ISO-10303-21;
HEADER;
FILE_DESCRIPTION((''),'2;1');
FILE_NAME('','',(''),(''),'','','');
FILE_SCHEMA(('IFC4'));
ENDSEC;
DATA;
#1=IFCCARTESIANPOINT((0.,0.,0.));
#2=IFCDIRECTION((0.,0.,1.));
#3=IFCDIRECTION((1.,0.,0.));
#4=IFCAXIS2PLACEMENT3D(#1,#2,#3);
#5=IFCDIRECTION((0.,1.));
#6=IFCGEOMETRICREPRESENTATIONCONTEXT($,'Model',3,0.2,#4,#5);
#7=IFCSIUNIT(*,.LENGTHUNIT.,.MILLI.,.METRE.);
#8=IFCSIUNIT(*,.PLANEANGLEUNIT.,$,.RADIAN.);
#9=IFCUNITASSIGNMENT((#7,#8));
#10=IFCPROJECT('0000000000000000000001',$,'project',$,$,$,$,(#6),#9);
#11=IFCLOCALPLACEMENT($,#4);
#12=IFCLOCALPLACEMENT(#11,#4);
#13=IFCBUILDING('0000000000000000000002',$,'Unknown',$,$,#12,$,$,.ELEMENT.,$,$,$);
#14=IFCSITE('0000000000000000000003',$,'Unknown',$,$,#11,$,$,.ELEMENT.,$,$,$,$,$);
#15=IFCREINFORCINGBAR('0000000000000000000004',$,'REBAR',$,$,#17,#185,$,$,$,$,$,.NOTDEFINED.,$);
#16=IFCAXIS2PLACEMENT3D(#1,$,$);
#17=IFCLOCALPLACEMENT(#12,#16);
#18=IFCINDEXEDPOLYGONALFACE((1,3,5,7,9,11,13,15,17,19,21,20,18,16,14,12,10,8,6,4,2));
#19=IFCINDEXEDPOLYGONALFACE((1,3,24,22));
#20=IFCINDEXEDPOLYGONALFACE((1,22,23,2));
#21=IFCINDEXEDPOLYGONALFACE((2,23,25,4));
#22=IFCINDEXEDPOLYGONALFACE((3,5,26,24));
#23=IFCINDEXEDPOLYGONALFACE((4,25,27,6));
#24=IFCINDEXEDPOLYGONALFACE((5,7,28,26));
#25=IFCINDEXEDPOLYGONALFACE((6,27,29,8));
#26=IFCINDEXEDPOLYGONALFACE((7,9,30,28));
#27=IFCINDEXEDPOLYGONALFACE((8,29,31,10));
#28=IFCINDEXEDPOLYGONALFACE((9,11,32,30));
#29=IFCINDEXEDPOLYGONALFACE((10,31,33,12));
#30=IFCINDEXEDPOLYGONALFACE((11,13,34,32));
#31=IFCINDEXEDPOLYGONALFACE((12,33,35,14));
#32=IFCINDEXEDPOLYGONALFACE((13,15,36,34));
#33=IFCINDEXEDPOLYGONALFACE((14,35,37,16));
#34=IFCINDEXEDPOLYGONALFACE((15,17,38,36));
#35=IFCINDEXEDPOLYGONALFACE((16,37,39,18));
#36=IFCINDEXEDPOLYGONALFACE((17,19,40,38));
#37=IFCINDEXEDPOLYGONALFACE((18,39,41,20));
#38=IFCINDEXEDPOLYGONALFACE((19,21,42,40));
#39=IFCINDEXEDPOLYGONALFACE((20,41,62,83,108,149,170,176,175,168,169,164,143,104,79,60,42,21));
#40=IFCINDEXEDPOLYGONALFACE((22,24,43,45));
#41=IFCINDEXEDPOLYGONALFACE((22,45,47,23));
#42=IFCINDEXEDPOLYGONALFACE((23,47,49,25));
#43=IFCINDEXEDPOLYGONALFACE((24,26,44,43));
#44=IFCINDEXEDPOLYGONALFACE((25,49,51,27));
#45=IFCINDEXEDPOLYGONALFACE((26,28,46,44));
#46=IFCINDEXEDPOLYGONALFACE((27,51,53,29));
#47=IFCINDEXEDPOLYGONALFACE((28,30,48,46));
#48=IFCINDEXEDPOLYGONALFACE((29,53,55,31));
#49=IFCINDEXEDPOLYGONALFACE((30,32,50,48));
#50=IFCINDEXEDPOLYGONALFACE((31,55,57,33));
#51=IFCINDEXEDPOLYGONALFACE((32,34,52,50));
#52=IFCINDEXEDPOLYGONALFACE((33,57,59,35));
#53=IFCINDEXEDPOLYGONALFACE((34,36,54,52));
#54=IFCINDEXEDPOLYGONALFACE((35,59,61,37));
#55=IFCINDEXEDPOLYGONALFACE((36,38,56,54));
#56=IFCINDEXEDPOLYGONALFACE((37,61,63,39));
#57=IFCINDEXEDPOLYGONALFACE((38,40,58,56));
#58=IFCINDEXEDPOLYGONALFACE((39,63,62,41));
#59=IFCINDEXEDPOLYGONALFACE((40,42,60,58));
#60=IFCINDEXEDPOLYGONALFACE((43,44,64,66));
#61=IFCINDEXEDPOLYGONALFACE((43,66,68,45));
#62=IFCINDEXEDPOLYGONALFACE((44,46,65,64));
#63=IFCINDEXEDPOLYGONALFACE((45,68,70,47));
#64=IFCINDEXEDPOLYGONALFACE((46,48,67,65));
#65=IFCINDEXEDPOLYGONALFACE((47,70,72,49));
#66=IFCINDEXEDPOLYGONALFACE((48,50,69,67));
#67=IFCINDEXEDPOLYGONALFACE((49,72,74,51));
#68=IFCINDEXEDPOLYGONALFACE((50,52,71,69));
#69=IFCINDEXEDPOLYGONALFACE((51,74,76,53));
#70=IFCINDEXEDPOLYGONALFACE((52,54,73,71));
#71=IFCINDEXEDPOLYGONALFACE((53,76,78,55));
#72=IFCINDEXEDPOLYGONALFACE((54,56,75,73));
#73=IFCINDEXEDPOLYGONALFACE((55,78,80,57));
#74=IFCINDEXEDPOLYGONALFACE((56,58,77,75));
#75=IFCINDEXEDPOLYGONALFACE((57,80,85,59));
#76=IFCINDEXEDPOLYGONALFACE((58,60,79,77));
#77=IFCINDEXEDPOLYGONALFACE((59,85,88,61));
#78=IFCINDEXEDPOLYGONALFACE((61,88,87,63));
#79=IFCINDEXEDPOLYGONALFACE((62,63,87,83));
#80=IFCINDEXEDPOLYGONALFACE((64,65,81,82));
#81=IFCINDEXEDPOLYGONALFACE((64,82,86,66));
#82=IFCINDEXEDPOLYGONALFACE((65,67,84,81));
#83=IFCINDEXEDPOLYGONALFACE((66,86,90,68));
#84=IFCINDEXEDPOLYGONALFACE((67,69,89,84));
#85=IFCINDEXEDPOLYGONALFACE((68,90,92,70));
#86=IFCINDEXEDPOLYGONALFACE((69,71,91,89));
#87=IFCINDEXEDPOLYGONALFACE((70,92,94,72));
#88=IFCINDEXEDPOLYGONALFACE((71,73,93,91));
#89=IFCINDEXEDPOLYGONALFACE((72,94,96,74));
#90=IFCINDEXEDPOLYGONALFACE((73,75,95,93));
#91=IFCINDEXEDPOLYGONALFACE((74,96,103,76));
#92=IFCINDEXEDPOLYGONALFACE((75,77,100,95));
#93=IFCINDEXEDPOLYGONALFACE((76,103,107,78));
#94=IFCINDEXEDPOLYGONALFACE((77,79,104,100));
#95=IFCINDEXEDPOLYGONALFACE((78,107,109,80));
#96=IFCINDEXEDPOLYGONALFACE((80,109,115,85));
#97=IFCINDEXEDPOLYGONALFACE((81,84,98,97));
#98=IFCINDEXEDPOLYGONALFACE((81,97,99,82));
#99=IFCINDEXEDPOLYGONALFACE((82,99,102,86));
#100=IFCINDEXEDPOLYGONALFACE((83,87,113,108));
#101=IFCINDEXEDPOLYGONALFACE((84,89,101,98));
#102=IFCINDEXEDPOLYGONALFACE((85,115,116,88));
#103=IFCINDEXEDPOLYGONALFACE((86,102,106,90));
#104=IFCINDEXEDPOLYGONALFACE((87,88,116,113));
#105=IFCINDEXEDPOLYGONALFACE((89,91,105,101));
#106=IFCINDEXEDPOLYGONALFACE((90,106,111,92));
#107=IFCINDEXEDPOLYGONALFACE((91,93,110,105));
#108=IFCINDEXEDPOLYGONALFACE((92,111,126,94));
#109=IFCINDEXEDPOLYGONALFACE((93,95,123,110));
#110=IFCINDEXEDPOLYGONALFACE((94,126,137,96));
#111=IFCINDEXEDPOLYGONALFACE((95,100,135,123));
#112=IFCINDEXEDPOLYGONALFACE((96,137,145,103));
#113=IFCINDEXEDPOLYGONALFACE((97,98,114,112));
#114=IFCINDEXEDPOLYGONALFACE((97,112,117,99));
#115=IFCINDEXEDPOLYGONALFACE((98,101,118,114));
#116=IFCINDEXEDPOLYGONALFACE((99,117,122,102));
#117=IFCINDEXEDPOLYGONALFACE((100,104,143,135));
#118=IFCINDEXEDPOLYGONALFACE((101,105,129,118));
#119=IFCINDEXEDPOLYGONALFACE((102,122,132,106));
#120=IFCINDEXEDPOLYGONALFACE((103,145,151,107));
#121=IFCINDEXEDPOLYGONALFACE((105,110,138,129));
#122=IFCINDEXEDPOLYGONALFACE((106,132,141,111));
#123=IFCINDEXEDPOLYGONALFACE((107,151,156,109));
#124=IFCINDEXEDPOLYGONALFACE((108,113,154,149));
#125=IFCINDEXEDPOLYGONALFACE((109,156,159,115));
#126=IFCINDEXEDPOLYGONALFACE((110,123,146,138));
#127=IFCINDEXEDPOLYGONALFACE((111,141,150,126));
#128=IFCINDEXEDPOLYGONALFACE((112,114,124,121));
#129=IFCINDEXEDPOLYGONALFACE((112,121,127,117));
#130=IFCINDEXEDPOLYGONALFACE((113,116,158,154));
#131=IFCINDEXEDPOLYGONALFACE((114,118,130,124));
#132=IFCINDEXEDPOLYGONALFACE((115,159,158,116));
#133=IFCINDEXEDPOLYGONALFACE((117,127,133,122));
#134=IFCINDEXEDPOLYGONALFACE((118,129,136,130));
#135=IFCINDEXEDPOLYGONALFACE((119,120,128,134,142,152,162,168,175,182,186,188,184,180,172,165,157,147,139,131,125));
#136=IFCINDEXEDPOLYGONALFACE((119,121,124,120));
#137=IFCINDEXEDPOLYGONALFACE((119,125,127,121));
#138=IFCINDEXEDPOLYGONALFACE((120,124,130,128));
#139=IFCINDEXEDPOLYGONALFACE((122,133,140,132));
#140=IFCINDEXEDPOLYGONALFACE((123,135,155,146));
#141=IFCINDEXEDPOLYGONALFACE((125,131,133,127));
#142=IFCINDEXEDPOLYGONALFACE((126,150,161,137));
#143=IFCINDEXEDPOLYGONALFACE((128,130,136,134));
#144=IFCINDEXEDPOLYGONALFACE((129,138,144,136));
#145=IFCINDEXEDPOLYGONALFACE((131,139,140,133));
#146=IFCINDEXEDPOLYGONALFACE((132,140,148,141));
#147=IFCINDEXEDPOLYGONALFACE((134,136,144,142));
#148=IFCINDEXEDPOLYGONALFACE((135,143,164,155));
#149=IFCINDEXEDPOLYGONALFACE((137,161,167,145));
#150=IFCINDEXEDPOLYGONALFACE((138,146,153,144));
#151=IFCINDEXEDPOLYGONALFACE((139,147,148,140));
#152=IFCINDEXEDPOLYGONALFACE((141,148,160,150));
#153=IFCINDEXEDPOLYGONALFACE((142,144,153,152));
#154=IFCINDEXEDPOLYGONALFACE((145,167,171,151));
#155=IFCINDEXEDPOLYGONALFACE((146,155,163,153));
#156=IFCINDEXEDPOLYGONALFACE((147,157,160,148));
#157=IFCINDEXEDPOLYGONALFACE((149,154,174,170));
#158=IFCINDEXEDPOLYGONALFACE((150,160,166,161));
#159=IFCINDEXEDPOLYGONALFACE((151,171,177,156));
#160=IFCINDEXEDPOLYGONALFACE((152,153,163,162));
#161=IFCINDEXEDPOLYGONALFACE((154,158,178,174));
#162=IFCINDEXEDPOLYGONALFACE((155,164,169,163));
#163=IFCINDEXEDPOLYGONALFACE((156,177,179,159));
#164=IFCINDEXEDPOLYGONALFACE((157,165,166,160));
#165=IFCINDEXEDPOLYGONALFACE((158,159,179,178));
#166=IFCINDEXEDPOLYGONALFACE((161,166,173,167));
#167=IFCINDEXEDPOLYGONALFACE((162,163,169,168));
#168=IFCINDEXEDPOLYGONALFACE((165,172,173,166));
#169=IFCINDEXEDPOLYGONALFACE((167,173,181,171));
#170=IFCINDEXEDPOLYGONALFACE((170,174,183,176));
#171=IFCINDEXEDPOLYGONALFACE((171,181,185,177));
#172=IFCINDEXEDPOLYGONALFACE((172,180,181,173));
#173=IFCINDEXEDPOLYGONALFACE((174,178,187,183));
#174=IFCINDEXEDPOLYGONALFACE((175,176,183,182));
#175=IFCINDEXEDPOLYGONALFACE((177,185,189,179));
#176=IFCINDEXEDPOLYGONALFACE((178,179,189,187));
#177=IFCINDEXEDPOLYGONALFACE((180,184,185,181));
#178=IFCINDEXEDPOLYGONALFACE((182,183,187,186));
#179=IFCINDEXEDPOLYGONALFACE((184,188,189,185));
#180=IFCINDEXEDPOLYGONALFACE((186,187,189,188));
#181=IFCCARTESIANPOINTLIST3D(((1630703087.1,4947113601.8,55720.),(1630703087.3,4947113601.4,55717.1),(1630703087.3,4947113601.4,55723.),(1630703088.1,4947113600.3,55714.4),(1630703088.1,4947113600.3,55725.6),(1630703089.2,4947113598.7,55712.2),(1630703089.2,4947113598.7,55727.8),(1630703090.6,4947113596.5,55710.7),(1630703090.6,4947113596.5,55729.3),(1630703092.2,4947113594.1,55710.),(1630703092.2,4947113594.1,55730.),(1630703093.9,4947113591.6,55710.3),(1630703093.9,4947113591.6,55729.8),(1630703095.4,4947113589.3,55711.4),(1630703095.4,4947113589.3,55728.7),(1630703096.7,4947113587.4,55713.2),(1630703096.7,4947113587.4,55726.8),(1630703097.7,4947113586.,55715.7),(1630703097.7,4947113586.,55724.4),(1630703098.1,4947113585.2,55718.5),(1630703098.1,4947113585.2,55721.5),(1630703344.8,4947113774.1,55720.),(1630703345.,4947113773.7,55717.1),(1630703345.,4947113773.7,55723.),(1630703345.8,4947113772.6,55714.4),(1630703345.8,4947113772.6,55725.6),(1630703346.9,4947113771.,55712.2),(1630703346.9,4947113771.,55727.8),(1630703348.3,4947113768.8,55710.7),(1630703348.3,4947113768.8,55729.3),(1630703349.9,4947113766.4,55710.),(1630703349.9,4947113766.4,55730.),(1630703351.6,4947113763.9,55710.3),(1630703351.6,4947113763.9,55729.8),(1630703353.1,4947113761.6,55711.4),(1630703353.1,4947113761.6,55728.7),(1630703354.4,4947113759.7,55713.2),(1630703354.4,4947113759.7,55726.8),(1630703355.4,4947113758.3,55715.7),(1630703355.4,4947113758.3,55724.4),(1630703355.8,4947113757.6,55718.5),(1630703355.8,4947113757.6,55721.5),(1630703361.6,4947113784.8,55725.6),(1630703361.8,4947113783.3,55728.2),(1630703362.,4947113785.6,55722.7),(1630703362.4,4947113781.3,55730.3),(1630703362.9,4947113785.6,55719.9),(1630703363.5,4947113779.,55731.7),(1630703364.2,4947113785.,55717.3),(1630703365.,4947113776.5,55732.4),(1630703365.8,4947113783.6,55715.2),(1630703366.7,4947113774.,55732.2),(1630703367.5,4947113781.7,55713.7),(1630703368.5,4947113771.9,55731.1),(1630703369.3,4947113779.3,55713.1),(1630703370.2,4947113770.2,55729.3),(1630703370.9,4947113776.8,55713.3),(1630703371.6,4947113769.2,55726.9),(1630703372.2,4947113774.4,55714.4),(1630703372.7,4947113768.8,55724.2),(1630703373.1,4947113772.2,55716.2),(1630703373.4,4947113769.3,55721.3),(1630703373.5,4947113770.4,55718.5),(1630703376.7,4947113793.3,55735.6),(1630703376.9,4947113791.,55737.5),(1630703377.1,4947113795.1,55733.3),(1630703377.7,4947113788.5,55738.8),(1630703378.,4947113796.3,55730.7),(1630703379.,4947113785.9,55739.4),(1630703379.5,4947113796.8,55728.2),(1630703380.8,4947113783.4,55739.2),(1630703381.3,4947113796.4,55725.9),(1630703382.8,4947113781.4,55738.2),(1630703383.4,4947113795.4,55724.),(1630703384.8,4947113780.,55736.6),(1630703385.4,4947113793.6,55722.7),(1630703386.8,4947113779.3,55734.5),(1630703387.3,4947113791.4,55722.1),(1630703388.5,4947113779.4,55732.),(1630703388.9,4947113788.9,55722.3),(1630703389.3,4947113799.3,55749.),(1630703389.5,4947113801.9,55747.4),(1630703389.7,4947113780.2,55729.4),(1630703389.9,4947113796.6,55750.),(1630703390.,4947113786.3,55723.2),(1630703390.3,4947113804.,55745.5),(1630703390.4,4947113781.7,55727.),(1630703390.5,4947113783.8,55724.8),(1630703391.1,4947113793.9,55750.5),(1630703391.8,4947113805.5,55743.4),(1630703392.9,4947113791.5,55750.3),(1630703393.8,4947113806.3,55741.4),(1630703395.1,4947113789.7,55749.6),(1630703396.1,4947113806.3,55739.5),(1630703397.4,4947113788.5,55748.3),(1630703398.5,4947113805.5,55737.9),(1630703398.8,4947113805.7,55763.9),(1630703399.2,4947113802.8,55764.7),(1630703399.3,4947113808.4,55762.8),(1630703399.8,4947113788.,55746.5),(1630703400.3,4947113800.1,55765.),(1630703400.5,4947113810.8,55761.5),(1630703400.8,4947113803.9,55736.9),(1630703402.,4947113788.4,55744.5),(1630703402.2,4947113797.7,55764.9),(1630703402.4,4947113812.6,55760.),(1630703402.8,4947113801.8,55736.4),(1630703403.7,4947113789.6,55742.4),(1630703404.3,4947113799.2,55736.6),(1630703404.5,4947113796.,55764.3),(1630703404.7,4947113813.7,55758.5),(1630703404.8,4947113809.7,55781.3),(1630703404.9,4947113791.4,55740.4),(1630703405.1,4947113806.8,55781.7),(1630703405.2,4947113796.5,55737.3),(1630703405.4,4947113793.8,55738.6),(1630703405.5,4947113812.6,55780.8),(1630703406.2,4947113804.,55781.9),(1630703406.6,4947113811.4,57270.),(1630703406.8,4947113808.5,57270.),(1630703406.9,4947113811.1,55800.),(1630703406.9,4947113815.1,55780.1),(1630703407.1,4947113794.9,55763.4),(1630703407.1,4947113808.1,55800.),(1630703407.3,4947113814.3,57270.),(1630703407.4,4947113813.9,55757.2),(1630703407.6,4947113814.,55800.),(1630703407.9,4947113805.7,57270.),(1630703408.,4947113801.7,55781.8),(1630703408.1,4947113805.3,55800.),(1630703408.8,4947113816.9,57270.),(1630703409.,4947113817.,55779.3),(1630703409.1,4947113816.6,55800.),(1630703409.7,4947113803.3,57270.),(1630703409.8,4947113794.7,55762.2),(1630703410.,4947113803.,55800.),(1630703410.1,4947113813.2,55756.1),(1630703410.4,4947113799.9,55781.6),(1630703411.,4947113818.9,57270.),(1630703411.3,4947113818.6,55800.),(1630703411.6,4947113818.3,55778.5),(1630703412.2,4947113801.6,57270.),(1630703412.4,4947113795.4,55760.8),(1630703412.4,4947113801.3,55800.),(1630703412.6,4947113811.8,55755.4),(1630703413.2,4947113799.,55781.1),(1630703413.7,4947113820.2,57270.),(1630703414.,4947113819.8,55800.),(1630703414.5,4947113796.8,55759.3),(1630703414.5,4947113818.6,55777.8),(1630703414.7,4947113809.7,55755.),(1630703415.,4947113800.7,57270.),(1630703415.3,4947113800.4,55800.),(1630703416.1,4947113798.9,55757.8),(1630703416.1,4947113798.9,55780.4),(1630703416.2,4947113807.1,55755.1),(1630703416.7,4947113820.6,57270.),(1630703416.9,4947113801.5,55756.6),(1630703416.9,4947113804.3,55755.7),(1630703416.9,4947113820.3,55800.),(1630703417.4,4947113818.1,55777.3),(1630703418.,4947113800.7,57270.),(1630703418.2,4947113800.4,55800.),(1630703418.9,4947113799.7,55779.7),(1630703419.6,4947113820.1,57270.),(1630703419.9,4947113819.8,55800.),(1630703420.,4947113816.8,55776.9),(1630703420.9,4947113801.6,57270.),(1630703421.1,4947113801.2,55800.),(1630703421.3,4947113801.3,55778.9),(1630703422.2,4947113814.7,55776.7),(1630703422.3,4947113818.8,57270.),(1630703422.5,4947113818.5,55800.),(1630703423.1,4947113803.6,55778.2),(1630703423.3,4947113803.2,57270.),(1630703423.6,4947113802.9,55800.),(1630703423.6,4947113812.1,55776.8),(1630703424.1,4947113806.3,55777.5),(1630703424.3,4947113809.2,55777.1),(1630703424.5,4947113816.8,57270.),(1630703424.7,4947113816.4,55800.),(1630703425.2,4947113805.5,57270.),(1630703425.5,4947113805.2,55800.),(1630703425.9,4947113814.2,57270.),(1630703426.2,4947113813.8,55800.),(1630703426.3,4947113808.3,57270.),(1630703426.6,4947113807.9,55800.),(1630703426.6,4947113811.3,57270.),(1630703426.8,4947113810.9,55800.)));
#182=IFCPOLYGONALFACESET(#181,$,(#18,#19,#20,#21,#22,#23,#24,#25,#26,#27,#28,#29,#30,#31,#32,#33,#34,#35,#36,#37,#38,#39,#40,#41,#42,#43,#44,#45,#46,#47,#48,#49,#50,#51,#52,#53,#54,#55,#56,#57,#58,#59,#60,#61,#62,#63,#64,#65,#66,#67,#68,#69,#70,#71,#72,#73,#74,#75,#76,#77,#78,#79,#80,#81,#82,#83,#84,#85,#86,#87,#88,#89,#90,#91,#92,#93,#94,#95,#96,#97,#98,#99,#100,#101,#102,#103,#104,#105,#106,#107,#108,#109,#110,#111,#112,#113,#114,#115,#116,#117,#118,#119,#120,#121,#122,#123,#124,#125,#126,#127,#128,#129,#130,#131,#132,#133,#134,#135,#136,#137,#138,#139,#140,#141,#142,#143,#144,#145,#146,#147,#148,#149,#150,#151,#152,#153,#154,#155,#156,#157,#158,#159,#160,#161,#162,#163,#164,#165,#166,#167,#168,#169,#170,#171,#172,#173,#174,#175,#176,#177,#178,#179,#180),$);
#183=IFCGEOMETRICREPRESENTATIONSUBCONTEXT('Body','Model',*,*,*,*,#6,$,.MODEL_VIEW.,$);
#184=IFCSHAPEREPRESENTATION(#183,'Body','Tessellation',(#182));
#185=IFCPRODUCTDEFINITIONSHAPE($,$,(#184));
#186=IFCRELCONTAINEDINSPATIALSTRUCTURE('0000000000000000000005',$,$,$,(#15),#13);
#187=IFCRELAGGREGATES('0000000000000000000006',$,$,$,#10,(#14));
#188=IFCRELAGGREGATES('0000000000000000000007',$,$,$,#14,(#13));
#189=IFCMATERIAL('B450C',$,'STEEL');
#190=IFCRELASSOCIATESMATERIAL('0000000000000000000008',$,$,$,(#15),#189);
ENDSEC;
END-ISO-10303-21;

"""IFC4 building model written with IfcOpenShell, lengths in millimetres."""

from ifc_helpers import new_model, entity, si_unit, direction, frame, origin_with_axes, place, context, subcontext, project, spatial, material, element, save


model = new_model("IFC4")

# Units and contexts
model_context = context("Model", 3, precision=0.2, world=origin_with_axes(), true_north=direction((0.0, 1.0)))
body_context = subcontext(model_context, "Body", "Model", "MODEL_VIEW")
ifc_project = project(units=[si_unit("LENGTHUNIT", "METRE", prefix="MILLI"), si_unit("PLANEANGLEUNIT", "RADIAN")], contexts=[model_context])

# Site, building
site_placement = place(None, origin_with_axes())
site = spatial("IfcSite", under=ifc_project, at=site_placement, Name="Unknown", CompositionType="ELEMENT")
building_placement = place(site_placement, origin_with_axes())
building = spatial("IfcBuilding", under=site, at=building_placement, Name="Unknown", CompositionType="ELEMENT")

# Reinforcing bar
ifc_material = material(Name="B450C", Category="STEEL")
reinforcing_bar_1_placement = place(building_placement, frame((1630703430.6, 4947113879.6, 55670.0), z_axis=(0.555817, -0.831305, 0.0), x_axis=(0.0, 0.0, 1.0)))
element("IfcReinforcingBar", 1, at=reinforcing_bar_1_placement, inside=building, material=ifc_material, Name="REBAR", PredefinedType="NOTDEFINED", context=body_context, shape_type="AdvancedSweptSolid", body=[
    entity("IfcSweptDiskSolid", entity("IfcIndexedPolyCurve", entity("IfcCartesianPointList3D", [[50.0, 440.0, 50.0], [50.0, 130.0, 50.0], [73.4, 73.4, 50.0], [130.0, 50.0, 50.0], [1600.0, 50.0, 49.5]]), [entity("IfcLineIndex", [1, 2]), entity("IfcArcIndex", [2, 3, 4]), entity("IfcLineIndex", [4, 5])]), 10.0),
])

save(model, "model.ifc")
